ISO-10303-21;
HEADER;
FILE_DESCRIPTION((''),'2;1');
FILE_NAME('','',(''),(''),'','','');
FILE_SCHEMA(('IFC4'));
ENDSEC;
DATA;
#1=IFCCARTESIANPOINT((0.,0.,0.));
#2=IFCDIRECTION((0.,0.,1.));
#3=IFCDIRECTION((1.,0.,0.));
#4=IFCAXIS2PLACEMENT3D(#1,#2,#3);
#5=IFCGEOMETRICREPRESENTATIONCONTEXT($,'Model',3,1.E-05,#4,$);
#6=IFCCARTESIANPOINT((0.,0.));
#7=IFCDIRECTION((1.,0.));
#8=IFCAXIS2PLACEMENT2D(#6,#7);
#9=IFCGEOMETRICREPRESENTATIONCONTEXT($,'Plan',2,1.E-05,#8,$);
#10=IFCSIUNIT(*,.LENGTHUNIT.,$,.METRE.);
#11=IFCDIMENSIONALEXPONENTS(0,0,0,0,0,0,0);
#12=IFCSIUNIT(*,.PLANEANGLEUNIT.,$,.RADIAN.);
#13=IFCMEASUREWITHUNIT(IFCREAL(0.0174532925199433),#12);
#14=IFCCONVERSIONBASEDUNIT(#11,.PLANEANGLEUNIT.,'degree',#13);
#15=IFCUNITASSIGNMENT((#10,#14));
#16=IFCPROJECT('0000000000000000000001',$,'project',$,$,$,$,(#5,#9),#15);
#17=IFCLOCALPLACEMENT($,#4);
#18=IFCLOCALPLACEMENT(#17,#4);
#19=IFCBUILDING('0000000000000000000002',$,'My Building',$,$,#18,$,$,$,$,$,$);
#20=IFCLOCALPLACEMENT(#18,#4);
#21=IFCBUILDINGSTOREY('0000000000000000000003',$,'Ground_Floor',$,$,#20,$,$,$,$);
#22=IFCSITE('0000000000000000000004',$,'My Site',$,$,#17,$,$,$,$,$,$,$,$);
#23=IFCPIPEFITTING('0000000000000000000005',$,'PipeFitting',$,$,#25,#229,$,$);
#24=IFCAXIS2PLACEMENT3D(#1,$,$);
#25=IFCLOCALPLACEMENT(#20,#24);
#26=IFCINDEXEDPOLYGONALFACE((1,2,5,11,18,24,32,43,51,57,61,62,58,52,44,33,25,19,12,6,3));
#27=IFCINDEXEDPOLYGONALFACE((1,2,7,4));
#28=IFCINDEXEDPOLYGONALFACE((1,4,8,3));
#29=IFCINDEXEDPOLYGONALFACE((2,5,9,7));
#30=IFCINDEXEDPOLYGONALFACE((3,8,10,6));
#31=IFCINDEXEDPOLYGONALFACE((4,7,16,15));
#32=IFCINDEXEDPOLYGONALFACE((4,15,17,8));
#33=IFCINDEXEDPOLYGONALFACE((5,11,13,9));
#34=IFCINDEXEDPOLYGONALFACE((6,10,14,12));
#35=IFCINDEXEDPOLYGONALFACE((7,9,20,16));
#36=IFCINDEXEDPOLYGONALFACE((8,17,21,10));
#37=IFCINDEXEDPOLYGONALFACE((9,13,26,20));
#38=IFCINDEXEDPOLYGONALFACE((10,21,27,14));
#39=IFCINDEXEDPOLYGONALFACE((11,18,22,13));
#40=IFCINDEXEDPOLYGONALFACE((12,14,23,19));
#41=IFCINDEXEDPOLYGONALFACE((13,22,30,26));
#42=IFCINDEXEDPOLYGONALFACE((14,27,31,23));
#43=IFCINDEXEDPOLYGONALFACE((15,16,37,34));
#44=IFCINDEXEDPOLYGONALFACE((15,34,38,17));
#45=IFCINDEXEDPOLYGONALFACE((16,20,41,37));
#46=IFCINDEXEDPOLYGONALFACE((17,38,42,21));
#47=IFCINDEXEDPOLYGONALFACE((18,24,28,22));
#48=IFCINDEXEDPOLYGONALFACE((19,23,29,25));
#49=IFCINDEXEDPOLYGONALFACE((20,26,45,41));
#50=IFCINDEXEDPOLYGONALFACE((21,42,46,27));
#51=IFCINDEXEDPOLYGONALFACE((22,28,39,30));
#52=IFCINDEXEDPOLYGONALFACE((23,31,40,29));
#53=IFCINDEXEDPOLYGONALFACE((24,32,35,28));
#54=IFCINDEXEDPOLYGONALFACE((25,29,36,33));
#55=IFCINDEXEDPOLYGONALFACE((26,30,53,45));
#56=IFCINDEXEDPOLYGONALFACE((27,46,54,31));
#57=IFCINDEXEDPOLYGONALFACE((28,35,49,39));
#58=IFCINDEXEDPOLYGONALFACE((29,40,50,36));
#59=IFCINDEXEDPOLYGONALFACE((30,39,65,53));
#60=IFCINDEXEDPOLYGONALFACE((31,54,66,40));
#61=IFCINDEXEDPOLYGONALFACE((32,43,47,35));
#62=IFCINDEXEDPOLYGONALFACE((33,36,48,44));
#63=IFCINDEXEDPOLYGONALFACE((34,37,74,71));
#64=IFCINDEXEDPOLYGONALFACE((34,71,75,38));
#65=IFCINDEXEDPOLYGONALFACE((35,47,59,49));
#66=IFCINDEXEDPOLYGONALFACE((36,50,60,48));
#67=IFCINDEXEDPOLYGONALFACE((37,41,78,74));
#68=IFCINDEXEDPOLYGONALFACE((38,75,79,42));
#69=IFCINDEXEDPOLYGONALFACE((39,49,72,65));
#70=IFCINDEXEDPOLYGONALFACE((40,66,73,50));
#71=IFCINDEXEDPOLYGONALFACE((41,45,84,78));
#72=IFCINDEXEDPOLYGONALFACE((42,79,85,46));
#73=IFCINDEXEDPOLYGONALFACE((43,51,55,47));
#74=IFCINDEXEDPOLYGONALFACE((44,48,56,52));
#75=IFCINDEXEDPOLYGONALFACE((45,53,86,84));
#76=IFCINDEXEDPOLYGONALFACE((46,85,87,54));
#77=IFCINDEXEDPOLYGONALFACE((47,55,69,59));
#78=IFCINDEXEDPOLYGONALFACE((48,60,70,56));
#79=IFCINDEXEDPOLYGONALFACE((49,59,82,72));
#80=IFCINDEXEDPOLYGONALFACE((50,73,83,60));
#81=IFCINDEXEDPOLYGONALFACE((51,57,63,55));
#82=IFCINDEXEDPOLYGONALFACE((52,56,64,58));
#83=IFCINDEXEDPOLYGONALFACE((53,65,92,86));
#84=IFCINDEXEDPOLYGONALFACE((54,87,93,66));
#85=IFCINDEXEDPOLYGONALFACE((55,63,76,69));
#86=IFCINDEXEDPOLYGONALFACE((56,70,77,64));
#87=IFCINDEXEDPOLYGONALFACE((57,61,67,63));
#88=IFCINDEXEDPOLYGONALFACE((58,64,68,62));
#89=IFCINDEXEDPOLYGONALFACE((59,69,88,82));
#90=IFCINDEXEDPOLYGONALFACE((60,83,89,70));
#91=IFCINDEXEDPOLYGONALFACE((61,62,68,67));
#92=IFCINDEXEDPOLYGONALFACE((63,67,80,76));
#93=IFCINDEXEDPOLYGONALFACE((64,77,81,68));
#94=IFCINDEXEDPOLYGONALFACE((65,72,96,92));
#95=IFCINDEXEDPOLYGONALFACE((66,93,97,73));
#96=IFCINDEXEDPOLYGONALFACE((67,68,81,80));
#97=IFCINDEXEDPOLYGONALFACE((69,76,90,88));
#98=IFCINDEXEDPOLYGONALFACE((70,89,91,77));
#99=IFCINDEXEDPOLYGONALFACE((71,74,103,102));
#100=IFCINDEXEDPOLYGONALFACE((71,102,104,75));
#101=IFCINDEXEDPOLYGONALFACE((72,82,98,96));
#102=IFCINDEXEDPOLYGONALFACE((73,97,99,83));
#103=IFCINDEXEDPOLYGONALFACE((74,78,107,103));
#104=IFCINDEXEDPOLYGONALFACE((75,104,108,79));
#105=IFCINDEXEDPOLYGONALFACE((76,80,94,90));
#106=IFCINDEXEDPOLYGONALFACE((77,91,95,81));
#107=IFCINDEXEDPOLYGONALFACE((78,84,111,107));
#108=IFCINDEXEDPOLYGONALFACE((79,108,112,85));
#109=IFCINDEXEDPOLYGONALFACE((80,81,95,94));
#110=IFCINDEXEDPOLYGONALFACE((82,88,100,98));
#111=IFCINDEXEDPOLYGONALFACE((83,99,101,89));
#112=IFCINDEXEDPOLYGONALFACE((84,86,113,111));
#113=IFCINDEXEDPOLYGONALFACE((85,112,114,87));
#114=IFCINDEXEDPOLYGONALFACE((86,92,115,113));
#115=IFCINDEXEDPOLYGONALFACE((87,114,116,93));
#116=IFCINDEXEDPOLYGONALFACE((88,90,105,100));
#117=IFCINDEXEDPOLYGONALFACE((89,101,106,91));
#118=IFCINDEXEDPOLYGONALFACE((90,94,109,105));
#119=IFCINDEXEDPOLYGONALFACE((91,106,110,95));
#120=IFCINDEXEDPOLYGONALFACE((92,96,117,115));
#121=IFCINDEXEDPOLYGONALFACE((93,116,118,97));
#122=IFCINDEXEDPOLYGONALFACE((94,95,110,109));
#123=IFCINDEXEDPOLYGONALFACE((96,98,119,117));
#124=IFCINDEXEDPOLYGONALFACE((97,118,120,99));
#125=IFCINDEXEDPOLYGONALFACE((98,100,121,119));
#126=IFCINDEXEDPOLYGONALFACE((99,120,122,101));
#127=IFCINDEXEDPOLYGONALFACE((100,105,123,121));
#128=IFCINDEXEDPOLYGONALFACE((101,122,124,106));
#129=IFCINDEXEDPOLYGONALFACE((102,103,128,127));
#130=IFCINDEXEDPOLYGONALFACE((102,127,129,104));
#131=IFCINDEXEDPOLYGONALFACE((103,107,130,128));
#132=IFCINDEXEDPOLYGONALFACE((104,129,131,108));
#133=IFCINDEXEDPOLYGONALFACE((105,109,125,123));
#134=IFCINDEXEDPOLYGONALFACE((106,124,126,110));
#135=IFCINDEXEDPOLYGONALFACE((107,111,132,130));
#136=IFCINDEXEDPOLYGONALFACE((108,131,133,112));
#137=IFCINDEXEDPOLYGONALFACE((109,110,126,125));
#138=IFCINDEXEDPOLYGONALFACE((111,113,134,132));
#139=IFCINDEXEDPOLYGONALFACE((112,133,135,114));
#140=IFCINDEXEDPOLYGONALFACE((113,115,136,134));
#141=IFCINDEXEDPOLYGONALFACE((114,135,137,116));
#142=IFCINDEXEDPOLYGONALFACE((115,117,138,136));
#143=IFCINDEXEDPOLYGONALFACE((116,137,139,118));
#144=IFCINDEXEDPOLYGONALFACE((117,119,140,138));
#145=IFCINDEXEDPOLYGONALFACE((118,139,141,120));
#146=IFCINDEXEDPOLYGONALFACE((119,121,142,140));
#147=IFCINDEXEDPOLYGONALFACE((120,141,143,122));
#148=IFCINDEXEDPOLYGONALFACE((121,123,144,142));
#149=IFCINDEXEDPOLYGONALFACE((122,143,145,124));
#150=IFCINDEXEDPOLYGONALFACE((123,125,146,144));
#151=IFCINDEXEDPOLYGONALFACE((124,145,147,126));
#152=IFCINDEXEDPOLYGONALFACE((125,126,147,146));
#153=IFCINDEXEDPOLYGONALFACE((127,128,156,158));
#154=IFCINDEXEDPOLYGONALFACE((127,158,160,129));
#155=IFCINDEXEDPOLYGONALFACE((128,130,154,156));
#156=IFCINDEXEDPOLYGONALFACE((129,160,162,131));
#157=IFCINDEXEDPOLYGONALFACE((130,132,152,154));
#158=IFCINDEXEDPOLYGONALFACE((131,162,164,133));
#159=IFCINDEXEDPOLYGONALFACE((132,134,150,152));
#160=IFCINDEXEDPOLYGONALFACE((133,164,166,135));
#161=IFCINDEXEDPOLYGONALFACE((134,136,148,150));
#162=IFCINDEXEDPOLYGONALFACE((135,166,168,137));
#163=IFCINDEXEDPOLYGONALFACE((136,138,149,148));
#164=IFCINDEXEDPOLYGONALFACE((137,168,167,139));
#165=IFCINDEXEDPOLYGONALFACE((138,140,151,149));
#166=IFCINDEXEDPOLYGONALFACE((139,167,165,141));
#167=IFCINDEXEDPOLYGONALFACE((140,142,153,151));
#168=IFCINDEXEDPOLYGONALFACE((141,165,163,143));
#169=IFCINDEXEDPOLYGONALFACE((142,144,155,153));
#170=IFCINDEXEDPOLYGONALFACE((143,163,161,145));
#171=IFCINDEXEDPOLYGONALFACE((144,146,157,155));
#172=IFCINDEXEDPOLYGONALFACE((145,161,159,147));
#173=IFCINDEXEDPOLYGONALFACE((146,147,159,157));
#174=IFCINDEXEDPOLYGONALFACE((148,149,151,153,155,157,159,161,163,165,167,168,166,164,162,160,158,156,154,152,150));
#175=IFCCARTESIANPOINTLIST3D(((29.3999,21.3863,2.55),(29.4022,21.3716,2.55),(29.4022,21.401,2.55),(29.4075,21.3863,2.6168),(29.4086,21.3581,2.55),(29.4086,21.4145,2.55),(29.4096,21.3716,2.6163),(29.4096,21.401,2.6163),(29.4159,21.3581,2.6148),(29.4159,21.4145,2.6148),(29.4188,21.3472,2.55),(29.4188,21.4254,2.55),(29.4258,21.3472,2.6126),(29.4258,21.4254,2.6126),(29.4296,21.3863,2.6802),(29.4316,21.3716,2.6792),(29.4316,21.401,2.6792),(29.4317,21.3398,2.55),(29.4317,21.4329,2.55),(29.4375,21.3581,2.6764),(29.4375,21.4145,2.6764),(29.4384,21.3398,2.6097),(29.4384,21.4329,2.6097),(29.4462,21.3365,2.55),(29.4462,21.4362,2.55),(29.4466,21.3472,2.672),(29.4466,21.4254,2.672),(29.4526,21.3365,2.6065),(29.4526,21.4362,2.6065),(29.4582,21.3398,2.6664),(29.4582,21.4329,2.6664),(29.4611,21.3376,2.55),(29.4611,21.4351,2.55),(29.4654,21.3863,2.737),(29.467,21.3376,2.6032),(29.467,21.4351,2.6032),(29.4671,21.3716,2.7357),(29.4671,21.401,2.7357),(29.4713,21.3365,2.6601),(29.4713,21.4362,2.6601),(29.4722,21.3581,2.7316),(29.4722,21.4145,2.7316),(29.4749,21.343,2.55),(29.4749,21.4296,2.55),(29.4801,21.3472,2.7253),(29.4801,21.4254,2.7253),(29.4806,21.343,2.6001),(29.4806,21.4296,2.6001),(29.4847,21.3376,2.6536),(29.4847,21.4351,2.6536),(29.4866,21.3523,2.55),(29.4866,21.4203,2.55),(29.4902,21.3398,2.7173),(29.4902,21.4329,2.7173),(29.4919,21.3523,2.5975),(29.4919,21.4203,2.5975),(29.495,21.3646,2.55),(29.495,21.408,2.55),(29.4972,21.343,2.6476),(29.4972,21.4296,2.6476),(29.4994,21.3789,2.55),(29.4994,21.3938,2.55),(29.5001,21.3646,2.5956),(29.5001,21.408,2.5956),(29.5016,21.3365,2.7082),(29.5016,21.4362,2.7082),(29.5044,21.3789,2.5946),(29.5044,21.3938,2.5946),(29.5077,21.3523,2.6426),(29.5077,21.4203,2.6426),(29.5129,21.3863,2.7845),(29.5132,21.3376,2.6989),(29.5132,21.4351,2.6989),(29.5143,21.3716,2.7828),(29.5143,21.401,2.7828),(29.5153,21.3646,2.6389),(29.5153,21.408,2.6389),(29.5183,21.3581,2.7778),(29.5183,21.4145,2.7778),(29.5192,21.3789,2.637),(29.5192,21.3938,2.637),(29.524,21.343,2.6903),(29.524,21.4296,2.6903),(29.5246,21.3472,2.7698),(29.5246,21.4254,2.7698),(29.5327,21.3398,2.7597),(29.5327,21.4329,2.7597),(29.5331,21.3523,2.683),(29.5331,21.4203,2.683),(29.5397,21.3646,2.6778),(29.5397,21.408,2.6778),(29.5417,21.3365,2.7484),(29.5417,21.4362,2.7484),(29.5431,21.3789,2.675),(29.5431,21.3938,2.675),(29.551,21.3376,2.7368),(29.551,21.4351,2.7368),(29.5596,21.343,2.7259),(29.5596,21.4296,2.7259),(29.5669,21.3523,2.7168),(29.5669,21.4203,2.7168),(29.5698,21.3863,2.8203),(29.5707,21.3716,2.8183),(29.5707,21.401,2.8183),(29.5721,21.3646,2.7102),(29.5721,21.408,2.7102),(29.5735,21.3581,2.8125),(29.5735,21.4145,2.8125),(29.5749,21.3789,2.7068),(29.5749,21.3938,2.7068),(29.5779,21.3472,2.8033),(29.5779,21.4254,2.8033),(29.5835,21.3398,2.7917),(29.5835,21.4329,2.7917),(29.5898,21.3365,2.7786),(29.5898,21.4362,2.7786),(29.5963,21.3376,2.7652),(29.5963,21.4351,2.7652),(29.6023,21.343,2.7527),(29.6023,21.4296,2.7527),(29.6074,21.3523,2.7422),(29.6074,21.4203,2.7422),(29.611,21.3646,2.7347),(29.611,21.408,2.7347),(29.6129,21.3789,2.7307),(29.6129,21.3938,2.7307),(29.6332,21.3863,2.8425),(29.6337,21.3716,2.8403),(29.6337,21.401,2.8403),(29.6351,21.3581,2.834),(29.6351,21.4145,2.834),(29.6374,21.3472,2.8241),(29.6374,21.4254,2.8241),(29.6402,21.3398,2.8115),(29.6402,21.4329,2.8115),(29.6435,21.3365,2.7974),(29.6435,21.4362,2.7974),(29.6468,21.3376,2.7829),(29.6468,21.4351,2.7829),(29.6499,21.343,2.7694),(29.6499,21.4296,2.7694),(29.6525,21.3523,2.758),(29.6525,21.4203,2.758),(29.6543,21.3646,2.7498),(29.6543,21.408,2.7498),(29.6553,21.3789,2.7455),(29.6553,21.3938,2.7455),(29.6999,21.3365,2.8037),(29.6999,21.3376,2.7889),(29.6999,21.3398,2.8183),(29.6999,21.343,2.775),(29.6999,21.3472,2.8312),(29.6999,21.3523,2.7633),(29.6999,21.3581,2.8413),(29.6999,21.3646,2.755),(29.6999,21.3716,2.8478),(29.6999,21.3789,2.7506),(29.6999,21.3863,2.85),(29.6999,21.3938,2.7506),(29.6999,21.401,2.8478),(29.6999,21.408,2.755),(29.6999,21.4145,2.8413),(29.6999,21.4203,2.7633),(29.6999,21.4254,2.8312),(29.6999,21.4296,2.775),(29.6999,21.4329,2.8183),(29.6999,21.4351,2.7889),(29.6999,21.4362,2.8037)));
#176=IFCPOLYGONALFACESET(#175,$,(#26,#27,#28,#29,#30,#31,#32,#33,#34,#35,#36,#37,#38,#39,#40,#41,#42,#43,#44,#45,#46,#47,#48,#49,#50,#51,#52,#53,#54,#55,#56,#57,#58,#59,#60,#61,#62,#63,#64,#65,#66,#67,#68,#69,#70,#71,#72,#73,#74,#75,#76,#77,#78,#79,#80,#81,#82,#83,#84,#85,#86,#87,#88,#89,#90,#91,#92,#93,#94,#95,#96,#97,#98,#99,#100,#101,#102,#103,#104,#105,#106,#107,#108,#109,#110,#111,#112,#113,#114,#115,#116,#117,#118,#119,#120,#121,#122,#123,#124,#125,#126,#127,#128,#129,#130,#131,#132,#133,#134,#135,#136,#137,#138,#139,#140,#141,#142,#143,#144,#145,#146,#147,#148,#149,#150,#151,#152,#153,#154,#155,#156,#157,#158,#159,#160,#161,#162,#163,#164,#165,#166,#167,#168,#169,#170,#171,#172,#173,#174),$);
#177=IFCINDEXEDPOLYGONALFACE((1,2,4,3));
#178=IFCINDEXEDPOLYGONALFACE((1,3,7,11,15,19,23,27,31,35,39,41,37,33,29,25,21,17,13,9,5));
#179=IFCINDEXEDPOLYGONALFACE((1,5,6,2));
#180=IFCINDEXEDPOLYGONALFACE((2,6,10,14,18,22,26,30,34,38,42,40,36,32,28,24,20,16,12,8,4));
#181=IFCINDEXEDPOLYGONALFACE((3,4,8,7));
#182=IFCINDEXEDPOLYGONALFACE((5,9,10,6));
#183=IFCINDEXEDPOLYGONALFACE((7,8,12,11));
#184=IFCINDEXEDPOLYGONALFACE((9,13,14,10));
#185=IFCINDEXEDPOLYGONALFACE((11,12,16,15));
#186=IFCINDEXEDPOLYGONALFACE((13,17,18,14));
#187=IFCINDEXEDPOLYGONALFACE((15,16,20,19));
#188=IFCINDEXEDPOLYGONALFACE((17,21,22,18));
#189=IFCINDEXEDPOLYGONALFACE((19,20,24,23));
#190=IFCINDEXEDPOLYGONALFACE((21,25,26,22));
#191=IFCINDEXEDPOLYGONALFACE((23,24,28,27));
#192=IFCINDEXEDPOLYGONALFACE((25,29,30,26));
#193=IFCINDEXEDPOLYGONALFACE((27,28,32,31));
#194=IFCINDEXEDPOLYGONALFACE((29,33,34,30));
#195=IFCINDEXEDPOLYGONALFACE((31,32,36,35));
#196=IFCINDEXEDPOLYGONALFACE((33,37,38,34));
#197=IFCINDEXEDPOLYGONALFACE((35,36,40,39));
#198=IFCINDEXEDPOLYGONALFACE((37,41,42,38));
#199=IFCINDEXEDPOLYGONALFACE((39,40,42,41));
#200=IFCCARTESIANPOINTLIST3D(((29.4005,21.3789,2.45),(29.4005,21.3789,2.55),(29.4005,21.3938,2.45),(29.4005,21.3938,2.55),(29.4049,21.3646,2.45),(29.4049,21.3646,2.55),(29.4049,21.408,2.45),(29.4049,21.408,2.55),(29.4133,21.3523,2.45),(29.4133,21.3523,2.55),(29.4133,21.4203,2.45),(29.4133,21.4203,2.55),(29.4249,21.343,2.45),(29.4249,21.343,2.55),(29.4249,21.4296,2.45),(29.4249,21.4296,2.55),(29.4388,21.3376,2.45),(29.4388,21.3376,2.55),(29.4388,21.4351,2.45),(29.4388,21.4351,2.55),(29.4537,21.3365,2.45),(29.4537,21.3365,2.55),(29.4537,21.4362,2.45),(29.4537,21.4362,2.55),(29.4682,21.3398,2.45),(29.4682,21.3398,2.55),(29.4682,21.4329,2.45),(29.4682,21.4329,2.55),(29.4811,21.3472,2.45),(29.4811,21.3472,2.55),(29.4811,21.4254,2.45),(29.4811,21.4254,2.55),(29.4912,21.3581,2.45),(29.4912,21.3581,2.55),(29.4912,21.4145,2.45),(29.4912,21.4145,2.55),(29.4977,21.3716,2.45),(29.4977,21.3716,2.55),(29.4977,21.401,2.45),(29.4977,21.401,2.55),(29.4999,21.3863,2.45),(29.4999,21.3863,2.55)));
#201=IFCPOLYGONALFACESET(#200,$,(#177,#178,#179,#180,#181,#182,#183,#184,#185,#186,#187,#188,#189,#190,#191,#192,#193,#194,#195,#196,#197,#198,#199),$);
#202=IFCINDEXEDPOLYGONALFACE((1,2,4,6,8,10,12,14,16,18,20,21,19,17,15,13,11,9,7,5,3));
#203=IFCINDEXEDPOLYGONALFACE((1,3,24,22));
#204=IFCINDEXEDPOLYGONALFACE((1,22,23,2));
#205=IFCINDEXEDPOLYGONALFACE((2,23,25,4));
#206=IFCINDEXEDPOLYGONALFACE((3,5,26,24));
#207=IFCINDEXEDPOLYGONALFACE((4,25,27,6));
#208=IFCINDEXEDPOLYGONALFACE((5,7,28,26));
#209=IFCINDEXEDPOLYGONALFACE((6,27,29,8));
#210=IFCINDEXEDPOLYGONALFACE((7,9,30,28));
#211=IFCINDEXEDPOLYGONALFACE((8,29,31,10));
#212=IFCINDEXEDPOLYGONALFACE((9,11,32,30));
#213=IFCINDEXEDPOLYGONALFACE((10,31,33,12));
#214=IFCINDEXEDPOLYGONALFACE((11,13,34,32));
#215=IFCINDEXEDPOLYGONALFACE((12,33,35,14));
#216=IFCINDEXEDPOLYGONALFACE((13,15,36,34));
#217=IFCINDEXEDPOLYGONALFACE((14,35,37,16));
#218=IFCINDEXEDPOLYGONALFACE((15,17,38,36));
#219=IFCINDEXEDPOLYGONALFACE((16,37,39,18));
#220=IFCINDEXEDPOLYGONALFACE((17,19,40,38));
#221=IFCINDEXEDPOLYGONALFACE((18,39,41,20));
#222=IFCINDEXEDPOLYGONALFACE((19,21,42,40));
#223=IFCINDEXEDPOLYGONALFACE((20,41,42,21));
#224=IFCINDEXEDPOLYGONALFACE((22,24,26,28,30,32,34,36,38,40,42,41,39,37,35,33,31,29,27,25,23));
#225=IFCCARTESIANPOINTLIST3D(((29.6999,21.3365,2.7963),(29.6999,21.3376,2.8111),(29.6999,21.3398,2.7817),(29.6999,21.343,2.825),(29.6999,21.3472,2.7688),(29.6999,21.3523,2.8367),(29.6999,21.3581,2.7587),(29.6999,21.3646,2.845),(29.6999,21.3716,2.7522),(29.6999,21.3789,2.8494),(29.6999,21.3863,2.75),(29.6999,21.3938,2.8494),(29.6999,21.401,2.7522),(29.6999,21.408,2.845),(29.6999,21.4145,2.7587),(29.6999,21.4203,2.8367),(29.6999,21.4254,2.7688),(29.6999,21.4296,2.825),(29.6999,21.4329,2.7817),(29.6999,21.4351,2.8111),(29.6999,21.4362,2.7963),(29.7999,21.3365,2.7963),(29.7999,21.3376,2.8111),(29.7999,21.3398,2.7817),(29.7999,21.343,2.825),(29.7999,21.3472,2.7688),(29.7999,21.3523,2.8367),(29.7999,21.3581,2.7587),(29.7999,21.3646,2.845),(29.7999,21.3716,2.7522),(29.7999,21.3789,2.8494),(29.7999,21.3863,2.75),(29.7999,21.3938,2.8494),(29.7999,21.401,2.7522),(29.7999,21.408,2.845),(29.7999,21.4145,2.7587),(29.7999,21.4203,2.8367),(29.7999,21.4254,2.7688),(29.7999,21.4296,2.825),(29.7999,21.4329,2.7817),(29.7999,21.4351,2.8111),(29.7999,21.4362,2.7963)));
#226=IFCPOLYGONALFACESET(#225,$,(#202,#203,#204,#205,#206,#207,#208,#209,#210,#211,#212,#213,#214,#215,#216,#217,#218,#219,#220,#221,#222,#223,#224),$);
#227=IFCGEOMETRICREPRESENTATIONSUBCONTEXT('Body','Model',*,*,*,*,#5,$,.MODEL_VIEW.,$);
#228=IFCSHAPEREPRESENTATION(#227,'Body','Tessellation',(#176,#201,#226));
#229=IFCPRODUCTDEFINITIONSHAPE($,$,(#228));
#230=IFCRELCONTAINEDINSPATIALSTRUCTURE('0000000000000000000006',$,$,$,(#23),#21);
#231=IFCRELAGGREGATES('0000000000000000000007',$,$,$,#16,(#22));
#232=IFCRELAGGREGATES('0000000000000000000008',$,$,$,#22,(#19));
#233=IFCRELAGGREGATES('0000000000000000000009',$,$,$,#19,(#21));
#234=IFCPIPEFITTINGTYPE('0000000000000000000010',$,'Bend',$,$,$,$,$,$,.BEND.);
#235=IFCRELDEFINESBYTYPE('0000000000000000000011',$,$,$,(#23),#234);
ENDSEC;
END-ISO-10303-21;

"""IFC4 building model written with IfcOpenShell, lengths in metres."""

from ifc_helpers import new_model, entity, si_unit, converted_unit, frame, origin_with_axes, origin_2d_with_axis, place, context, subcontext, project, spatial, circle, extrude, source, transform, mapped, type_object, type_shapes, element, save


model = new_model("IFC4")

# Units and contexts
model_context = context("Model", 3, precision=1e-05, world=origin_with_axes())
plan_context = context("Plan", 2, precision=1e-05, world=origin_2d_with_axis())
body_context = subcontext(model_context, "Body", "Model", "MODEL_VIEW")
ifc_project = project(units=[si_unit("LENGTHUNIT", "METRE"), converted_unit("PLANEANGLEUNIT", "degree", entity("IfcReal", 0.0174532925199433), si_unit("PLANEANGLEUNIT", "RADIAN"), dimensions=[0, 0, 0, 0, 0, 0, 0])], contexts=[model_context, plan_context])

# Site, building, storey
site_placement = place(None, origin_with_axes())
site = spatial("IfcSite", under=ifc_project, at=site_placement, Name="My Site")
building_placement = place(site_placement, origin_with_axes())
building = spatial("IfcBuilding", under=site, at=building_placement, Name="My Building")
storey_placement = place(building_placement, origin_with_axes())
storey = spatial("IfcBuildingStorey", under=building, at=storey_placement, Name="Ground_Floor")

# Pipe fitting
pipe_fitting_type = type_object("IfcPipeFittingType", Name="Bend", PredefinedType="BEND")
shared_shape = source(origin_with_axes(), body_context, "Body", "SolidModel", [
    entity("IfcSweptDiskSolid", entity("IfcIndexedPolyCurve", entity("IfcCartesianPointList3D", [[0.0, 0.0, -0.1], [0.0732, 0.0, -0.2768], [0.25, 0.0, -0.35]]), [entity("IfcArcIndex", [1, 2, 3])]), 0.05),
    extrude(circle(Radius=0.05), origin_with_axes(), (0.0, 0.0, -1.0), 0.1),
    extrude(circle(Radius=0.05), frame((0.25, 0.0, -0.35), z_axis=(1.0, 0.0, 0.0), x_axis=(0.0, 0.0, 1.0)), (0.0, 0.0, 1.0), 0.1),
])
type_shapes(pipe_fitting_type, [shared_shape])
for number, where, z_axis, x_axis, name in (
    (1, (29.4499, 21.3863, 2.45), (0.0, 0.0, -1.0), (1.0, 0.0, 0.0), "PipeFitting"),
):
    element("IfcPipeFitting", number, at=place(storey_placement, frame(where, z_axis=z_axis, x_axis=x_axis)), inside=storey, type_object=pipe_fitting_type, Name=name, context=body_context, shape_type="MappedRepresentation", body=[
        mapped(shared_shape, transform((0.0, 0.0, 0.0), x_axis=(1.0, 0.0, 0.0), y_axis=(0.0, 1.0, 0.0), z_axis=(0.0, 0.0, 1.0), scale=1.0)),
    ])

save(model, "model.ifc")
